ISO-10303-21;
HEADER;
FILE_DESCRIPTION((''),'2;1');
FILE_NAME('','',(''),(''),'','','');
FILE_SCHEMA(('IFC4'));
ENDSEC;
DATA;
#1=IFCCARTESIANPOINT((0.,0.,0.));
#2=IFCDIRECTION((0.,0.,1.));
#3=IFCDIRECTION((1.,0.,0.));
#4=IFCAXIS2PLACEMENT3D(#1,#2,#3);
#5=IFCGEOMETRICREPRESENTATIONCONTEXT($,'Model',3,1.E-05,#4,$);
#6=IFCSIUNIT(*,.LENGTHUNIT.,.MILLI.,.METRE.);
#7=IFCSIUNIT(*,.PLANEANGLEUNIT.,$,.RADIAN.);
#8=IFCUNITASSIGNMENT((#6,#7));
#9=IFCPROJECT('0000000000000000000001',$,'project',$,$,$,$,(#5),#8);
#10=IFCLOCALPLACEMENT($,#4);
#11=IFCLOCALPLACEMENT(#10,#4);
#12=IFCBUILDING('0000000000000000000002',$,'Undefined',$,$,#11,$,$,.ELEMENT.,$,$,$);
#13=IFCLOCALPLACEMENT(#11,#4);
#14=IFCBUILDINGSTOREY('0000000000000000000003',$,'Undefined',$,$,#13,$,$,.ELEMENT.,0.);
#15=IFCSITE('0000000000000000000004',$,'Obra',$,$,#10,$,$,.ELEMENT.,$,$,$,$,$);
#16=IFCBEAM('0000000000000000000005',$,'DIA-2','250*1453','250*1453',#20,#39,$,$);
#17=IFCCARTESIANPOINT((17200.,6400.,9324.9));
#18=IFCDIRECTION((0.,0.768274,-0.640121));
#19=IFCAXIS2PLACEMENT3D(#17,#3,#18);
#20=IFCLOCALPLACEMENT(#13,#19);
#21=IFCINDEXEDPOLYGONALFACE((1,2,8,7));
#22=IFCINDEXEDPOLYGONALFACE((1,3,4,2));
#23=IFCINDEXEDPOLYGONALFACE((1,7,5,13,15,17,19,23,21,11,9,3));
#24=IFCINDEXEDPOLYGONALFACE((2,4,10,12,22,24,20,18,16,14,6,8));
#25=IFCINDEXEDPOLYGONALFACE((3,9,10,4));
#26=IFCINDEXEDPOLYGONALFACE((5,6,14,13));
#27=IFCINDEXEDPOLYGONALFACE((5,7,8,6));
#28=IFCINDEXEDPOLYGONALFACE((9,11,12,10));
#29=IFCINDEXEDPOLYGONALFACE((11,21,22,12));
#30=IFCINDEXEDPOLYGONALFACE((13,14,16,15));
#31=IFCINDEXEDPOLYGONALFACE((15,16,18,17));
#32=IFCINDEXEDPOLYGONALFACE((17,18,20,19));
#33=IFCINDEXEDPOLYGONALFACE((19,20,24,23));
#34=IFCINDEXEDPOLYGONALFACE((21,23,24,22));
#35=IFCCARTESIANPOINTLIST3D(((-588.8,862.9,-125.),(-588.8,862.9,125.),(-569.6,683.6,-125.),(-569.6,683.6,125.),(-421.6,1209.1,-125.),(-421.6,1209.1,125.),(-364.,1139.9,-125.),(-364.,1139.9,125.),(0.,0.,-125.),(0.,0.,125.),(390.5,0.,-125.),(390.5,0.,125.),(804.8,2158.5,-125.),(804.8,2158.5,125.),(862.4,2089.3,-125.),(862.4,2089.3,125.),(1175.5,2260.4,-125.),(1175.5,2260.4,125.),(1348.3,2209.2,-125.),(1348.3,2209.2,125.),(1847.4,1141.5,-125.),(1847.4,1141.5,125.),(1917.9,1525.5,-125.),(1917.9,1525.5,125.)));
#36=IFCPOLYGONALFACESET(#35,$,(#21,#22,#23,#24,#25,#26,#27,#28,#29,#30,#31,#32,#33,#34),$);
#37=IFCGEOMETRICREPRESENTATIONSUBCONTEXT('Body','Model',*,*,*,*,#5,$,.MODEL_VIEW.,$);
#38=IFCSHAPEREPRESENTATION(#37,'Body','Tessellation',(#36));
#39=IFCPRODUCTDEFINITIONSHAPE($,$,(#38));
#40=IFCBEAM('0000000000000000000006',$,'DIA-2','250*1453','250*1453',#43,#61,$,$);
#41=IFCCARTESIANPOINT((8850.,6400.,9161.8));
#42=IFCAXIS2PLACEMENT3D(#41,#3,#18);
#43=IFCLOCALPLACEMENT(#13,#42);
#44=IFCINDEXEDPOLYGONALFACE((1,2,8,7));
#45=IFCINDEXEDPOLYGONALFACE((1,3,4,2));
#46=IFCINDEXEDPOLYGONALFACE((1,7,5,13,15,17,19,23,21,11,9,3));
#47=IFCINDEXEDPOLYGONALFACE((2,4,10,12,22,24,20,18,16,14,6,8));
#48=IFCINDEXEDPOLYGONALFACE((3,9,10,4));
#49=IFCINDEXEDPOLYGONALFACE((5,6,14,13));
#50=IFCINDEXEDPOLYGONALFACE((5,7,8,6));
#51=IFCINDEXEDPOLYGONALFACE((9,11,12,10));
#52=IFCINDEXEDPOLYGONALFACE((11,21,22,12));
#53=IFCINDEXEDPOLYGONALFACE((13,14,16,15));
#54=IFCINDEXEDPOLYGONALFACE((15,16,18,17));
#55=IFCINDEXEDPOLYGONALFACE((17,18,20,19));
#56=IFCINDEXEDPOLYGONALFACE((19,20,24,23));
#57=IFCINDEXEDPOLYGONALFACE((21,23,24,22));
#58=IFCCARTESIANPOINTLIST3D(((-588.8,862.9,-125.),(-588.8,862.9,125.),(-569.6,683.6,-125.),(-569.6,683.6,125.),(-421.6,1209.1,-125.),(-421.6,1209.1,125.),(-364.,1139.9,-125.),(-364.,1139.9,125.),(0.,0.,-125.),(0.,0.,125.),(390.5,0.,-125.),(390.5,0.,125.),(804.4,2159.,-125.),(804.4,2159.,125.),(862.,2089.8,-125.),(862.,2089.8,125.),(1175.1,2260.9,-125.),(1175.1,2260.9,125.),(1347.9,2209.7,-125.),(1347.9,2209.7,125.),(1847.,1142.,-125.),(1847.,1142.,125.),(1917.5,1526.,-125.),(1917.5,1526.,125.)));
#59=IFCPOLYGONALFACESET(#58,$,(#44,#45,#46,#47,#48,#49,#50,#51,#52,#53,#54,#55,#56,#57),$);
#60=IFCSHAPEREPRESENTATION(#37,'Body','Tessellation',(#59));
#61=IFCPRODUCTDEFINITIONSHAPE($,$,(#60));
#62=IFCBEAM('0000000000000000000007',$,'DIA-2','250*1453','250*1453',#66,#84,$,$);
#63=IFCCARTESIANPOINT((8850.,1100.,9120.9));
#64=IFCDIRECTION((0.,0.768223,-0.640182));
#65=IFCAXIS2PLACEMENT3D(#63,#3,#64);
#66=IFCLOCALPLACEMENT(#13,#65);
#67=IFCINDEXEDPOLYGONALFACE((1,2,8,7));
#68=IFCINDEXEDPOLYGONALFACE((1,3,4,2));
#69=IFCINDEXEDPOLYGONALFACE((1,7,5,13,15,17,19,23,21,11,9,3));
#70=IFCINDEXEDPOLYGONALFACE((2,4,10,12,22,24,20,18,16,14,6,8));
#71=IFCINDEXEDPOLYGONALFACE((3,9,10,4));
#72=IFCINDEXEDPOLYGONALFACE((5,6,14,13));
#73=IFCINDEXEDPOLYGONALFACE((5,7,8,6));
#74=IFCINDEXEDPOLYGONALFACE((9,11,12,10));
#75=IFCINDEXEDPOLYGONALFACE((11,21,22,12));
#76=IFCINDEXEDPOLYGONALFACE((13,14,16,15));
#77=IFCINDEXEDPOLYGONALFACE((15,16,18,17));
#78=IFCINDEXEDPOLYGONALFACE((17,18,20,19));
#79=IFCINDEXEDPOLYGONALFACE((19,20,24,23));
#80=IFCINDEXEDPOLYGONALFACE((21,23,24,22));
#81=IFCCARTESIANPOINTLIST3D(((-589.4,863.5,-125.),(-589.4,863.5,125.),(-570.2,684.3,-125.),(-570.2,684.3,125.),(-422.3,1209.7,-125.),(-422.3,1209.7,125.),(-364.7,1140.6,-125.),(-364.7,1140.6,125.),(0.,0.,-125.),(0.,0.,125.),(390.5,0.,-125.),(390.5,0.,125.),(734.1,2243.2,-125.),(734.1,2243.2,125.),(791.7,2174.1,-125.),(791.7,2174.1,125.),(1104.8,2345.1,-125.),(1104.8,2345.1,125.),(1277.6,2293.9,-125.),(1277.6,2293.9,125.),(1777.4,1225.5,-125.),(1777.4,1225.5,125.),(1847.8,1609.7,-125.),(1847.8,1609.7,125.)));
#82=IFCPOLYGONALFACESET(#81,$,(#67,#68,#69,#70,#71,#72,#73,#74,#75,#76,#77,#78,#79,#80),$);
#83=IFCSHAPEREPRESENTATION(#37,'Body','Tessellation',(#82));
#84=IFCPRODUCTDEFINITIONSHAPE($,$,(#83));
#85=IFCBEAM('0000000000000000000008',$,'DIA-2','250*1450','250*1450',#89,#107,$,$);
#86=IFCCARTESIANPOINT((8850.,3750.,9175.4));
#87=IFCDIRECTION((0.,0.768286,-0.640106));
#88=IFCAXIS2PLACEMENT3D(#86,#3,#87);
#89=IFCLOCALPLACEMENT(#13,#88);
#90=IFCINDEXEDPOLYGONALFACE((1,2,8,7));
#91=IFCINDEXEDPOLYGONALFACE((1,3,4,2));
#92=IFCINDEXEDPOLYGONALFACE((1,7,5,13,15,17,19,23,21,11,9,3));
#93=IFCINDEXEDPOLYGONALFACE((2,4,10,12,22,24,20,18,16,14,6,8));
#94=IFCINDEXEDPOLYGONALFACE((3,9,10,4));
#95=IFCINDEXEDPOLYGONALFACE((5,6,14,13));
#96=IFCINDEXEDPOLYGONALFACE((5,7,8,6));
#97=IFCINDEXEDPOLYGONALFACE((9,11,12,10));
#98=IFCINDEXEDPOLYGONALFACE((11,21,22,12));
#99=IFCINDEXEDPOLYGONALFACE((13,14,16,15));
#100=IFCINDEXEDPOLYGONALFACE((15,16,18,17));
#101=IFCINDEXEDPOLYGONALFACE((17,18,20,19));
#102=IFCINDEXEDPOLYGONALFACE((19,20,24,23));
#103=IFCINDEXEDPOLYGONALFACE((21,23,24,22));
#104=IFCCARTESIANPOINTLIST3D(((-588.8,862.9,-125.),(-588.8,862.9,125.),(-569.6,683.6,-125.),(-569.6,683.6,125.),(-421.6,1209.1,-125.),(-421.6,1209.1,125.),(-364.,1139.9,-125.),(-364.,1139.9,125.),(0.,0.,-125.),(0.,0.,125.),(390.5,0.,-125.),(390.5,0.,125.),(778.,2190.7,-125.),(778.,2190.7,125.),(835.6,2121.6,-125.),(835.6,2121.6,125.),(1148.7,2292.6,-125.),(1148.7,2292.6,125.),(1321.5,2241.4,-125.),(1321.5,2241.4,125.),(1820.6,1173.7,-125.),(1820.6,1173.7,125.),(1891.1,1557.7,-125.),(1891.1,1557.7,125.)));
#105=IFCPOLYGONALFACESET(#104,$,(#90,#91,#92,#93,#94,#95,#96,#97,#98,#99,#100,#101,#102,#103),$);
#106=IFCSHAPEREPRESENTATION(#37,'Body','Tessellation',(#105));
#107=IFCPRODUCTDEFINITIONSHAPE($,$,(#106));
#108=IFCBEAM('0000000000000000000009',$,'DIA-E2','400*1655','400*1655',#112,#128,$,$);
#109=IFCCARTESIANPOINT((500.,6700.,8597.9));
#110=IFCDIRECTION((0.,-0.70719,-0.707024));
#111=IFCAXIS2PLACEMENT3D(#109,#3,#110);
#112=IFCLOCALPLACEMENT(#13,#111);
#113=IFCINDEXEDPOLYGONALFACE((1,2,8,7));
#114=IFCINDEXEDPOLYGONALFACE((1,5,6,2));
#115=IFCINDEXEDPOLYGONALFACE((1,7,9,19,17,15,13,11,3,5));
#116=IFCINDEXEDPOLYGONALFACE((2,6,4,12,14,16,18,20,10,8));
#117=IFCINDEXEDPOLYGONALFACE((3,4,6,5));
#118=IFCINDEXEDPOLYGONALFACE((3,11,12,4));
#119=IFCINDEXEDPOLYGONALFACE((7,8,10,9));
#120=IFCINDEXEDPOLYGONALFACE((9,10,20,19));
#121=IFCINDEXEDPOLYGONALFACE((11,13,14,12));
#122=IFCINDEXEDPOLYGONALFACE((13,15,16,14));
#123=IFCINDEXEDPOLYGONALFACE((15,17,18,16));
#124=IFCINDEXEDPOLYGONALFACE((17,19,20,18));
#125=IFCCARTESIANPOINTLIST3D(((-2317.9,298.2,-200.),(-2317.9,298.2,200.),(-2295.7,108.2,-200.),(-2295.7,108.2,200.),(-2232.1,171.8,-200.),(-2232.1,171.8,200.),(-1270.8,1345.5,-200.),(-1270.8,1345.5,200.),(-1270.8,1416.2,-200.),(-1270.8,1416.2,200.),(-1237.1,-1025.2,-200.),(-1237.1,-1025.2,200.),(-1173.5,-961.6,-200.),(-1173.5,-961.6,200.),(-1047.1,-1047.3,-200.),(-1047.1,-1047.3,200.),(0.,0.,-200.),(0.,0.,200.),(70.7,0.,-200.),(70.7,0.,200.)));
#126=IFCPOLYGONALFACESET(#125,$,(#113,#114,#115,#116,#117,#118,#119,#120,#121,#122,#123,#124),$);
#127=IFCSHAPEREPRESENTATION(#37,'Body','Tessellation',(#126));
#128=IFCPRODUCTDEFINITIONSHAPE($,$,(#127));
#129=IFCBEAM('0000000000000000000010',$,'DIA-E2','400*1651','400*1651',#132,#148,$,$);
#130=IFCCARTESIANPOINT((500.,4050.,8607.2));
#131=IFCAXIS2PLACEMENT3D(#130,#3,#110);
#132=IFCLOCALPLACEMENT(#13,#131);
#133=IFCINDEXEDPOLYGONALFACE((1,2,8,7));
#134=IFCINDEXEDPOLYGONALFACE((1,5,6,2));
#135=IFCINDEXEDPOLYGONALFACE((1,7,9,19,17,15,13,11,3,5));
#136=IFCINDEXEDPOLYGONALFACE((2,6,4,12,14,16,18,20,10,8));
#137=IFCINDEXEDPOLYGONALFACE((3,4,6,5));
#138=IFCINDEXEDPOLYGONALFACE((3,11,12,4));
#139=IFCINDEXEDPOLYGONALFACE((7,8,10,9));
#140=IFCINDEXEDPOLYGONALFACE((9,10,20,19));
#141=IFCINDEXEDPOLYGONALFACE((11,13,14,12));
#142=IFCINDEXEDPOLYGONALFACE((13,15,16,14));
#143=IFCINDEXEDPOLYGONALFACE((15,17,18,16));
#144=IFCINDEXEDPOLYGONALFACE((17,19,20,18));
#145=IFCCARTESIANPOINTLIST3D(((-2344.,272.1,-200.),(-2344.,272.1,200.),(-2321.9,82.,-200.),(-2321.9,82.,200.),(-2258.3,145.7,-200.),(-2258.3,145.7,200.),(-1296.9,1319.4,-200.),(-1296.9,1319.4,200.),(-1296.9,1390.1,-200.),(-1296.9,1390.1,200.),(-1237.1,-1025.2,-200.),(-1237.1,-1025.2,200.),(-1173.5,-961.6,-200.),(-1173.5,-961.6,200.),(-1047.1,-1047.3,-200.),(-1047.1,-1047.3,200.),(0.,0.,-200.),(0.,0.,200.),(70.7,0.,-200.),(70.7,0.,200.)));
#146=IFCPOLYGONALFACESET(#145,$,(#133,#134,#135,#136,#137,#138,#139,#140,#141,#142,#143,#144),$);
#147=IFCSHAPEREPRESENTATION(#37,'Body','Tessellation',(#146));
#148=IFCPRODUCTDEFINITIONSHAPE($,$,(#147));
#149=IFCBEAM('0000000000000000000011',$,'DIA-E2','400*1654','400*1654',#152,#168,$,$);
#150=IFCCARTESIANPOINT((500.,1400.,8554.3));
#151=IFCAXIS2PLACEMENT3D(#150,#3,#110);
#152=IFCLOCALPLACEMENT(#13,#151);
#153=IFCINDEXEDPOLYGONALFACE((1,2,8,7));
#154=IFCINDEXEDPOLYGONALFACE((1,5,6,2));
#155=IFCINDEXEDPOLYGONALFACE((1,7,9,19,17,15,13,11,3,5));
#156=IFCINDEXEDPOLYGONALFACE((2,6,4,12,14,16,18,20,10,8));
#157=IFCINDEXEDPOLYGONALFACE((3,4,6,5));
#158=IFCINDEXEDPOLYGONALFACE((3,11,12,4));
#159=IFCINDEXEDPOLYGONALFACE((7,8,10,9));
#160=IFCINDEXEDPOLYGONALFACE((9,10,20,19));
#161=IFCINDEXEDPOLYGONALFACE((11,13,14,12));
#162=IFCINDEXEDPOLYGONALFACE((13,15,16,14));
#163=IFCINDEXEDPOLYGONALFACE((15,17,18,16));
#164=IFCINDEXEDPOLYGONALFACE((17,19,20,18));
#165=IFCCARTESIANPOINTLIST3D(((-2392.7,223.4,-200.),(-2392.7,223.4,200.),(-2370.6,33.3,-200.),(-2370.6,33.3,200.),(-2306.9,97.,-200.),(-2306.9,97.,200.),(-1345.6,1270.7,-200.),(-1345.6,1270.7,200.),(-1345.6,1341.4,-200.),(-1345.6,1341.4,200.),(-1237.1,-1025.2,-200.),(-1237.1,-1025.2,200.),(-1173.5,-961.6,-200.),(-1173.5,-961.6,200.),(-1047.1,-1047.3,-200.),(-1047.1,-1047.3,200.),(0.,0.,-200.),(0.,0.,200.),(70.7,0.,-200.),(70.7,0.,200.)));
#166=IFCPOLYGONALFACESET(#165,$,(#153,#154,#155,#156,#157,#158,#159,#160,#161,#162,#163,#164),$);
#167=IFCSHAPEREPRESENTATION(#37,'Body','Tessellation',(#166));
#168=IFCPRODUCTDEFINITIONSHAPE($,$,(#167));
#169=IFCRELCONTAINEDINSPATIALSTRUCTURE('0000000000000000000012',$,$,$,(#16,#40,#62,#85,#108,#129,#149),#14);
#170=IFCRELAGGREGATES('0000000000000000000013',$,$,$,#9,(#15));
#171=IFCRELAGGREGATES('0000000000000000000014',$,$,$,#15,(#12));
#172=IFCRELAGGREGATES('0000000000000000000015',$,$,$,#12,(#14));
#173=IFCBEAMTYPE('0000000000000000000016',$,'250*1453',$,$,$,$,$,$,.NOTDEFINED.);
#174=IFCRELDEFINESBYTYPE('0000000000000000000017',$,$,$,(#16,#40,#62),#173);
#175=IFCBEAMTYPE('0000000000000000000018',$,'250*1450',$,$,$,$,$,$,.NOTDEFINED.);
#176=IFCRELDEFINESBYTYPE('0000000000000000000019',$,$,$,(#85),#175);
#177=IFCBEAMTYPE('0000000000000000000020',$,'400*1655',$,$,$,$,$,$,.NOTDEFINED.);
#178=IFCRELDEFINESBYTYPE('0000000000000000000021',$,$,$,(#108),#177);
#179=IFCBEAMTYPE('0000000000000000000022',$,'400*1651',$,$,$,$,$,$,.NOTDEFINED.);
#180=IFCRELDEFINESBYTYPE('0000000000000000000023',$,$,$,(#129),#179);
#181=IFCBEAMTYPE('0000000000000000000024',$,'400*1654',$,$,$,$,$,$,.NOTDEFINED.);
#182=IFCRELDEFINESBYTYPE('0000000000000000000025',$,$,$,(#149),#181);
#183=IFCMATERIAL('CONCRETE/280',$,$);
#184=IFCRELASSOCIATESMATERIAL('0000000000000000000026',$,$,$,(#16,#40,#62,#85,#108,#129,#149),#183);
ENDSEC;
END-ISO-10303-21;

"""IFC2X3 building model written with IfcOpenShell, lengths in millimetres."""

from ifc_helpers import new_model, si_unit, frame, origin_with_axes, place, context, subcontext, project, spatial, polyline, outline, extrude, material, type_object, element, save


model = new_model("IFC2X3")

# Units and contexts
model_context = context("Model", 3, precision=1e-05, world=origin_with_axes())
body_context = subcontext(model_context, "Body", "Model", "MODEL_VIEW")
ifc_project = project(units=[si_unit("LENGTHUNIT", "METRE", prefix="MILLI"), si_unit("PLANEANGLEUNIT", "RADIAN")], contexts=[model_context])

# Site, building, storey
site_placement = place(None, origin_with_axes())
site = spatial("IfcSite", under=ifc_project, at=site_placement, Name="Obra", CompositionType="ELEMENT")
building_placement = place(site_placement, origin_with_axes())
building = spatial("IfcBuilding", under=site, at=building_placement, Name="Undefined", CompositionType="ELEMENT")
storey_placement = place(building_placement, origin_with_axes())
storey = spatial("IfcBuildingStorey", under=building, at=storey_placement, Name="Undefined", CompositionType="ELEMENT", Elevation=0.0)

# Shared definitions
ifc_material_1 = material(Name="CONCRETE/280")

# Beams
beam_type_1 = type_object("IfcBeamType", Name="250*1453", PredefinedType="NOTDEFINED")
beam_1_placement = place(storey_placement, frame((17200.0, 6400.0, 9324.9), z_axis=(1.0, 0.0, 0.0), x_axis=(0.0, 0.768274, -0.640121)))
element("IfcBeam", 1, at=beam_1_placement, inside=storey, type_object=beam_type_1, material=ifc_material_1, Name="DIA-2", Description="250*1453", ObjectType="250*1453", context=body_context, shape_type="SweptSolid", body=[
    extrude(outline(polyline([(0.0, 0.0), (390.5, 0.0), (1847.4, 1141.5), (1917.9, 1525.5), (1348.3, 2209.2), (1175.5, 2260.4), (862.4, 2089.3), (804.8, 2158.5), (-421.6, 1209.1), (-364.0, 1139.9), (-588.8, 862.9), (-569.6, 683.6), (0.0, 0.0)])), frame((0.0, 0.0, -125.0), z_axis=(0.0, 0.0, 1.0), x_axis=(1.0, 0.0, 0.0)), (0.0, 0.0, 1.0), 250.0),
])
beam_2_placement = place(storey_placement, frame((8850.0, 6400.0, 9161.8), z_axis=(1.0, 0.0, 0.0), x_axis=(0.0, 0.768274, -0.640121)))
element("IfcBeam", 2, at=beam_2_placement, inside=storey, type_object=beam_type_1, material=ifc_material_1, Name="DIA-2", Description="250*1453", ObjectType="250*1453", context=body_context, shape_type="SweptSolid", body=[
    extrude(outline(polyline([(0.0, 0.0), (390.5, 0.0), (1847.0, 1142.0), (1917.5, 1526.0), (1347.9, 2209.7), (1175.1, 2260.9), (862.0, 2089.8), (804.4, 2159.0), (-421.6, 1209.1), (-364.0, 1139.9), (-588.8, 862.9), (-569.6, 683.6), (0.0, 0.0)])), frame((0.0, 0.0, -125.0), z_axis=(0.0, 0.0, 1.0), x_axis=(1.0, 0.0, 0.0)), (0.0, 0.0, 1.0), 250.0),
])
beam_3_placement = place(storey_placement, frame((8850.0, 1100.0, 9120.9), z_axis=(1.0, 0.0, 0.0), x_axis=(0.0, 0.768223, -0.640182)))
element("IfcBeam", 3, at=beam_3_placement, inside=storey, type_object=beam_type_1, material=ifc_material_1, Name="DIA-2", Description="250*1453", ObjectType="250*1453", context=body_context, shape_type="SweptSolid", body=[
    extrude(outline(polyline([(0.0, 0.0), (390.5, 0.0), (1777.4, 1225.5), (1847.8, 1609.7), (1277.6, 2293.9), (1104.8, 2345.1), (791.7, 2174.1), (734.1, 2243.2), (-422.3, 1209.7), (-364.7, 1140.6), (-589.4, 863.5), (-570.2, 684.3), (0.0, 0.0)])), frame((0.0, 0.0, -125.0), z_axis=(0.0, 0.0, 1.0), x_axis=(1.0, 0.0, 0.0)), (0.0, 0.0, 1.0), 250.0),
])
beam_type_2 = type_object("IfcBeamType", Name="250*1450", PredefinedType="NOTDEFINED")
beam_4_placement = place(storey_placement, frame((8850.0, 3750.0, 9175.4), z_axis=(1.0, 0.0, 0.0), x_axis=(0.0, 0.768286, -0.640106)))
element("IfcBeam", 4, at=beam_4_placement, inside=storey, type_object=beam_type_2, material=ifc_material_1, Name="DIA-2", Description="250*1450", ObjectType="250*1450", context=body_context, shape_type="SweptSolid", body=[
    extrude(outline(polyline([(0.0, 0.0), (390.5, 0.0), (1820.6, 1173.7), (1891.1, 1557.7), (1321.5, 2241.4), (1148.7, 2292.6), (835.6, 2121.6), (778.0, 2190.7), (-421.6, 1209.1), (-364.0, 1139.9), (-588.8, 862.9), (-569.6, 683.6), (0.0, 0.0)])), frame((0.0, 0.0, -125.0), z_axis=(0.0, 0.0, 1.0), x_axis=(1.0, 0.0, 0.0)), (0.0, 0.0, 1.0), 250.0),
])
beam_type_3 = type_object("IfcBeamType", Name="400*1655", PredefinedType="NOTDEFINED")
beam_5_placement = place(storey_placement, frame((500.0, 6700.0, 8597.9), z_axis=(1.0, 0.0, 0.0), x_axis=(0.0, -0.70719, -0.707024)))
element("IfcBeam", 5, at=beam_5_placement, inside=storey, type_object=beam_type_3, material=ifc_material_1, Name="DIA-E2", Description="400*1655", ObjectType="400*1655", context=body_context, shape_type="SweptSolid", body=[
    extrude(outline(polyline([(0.0, 0.0), (70.7, 0.0), (-1270.8, 1416.2), (-1270.8, 1345.5), (-2317.9, 298.2), (-2232.1, 171.8), (-2295.7, 108.2), (-1237.1, -1025.2), (-1173.5, -961.6), (-1047.1, -1047.3), (0.0, 0.0)])), frame((0.0, 0.0, -200.0), z_axis=(0.0, 0.0, 1.0), x_axis=(1.0, 0.0, 0.0)), (0.0, 0.0, 1.0), 400.0),
])
beam_type_4 = type_object("IfcBeamType", Name="400*1651", PredefinedType="NOTDEFINED")
beam_6_placement = place(storey_placement, frame((500.0, 4050.0, 8607.2), z_axis=(1.0, 0.0, 0.0), x_axis=(0.0, -0.70719, -0.707024)))
element("IfcBeam", 6, at=beam_6_placement, inside=storey, type_object=beam_type_4, material=ifc_material_1, Name="DIA-E2", Description="400*1651", ObjectType="400*1651", context=body_context, shape_type="SweptSolid", body=[
    extrude(outline(polyline([(0.0, 0.0), (70.7, 0.0), (-1296.9, 1390.1), (-1296.9, 1319.4), (-2344.0, 272.1), (-2258.3, 145.7), (-2321.9, 82.0), (-1237.1, -1025.2), (-1173.5, -961.6), (-1047.1, -1047.3), (0.0, 0.0)])), frame((0.0, 0.0, -200.0), z_axis=(0.0, 0.0, 1.0), x_axis=(1.0, 0.0, 0.0)), (0.0, 0.0, 1.0), 400.0),
])
beam_type_5 = type_object("IfcBeamType", Name="400*1654", PredefinedType="NOTDEFINED")
beam_7_placement = place(storey_placement, frame((500.0, 1400.0, 8554.3), z_axis=(1.0, 0.0, 0.0), x_axis=(0.0, -0.70719, -0.707024)))
element("IfcBeam", 7, at=beam_7_placement, inside=storey, type_object=beam_type_5, material=ifc_material_1, Name="DIA-E2", Description="400*1654", ObjectType="400*1654", context=body_context, shape_type="SweptSolid", body=[
    extrude(outline(polyline([(0.0, 0.0), (70.7, 0.0), (-1345.6, 1341.4), (-1345.6, 1270.7), (-2392.7, 223.4), (-2306.9, 97.0), (-2370.6, 33.3), (-1237.1, -1025.2), (-1173.5, -961.6), (-1047.1, -1047.3), (0.0, 0.0)])), frame((0.0, 0.0, -200.0), z_axis=(0.0, 0.0, 1.0), x_axis=(1.0, 0.0, 0.0)), (0.0, 0.0, 1.0), 400.0),
])

save(model, "model.ifc")
